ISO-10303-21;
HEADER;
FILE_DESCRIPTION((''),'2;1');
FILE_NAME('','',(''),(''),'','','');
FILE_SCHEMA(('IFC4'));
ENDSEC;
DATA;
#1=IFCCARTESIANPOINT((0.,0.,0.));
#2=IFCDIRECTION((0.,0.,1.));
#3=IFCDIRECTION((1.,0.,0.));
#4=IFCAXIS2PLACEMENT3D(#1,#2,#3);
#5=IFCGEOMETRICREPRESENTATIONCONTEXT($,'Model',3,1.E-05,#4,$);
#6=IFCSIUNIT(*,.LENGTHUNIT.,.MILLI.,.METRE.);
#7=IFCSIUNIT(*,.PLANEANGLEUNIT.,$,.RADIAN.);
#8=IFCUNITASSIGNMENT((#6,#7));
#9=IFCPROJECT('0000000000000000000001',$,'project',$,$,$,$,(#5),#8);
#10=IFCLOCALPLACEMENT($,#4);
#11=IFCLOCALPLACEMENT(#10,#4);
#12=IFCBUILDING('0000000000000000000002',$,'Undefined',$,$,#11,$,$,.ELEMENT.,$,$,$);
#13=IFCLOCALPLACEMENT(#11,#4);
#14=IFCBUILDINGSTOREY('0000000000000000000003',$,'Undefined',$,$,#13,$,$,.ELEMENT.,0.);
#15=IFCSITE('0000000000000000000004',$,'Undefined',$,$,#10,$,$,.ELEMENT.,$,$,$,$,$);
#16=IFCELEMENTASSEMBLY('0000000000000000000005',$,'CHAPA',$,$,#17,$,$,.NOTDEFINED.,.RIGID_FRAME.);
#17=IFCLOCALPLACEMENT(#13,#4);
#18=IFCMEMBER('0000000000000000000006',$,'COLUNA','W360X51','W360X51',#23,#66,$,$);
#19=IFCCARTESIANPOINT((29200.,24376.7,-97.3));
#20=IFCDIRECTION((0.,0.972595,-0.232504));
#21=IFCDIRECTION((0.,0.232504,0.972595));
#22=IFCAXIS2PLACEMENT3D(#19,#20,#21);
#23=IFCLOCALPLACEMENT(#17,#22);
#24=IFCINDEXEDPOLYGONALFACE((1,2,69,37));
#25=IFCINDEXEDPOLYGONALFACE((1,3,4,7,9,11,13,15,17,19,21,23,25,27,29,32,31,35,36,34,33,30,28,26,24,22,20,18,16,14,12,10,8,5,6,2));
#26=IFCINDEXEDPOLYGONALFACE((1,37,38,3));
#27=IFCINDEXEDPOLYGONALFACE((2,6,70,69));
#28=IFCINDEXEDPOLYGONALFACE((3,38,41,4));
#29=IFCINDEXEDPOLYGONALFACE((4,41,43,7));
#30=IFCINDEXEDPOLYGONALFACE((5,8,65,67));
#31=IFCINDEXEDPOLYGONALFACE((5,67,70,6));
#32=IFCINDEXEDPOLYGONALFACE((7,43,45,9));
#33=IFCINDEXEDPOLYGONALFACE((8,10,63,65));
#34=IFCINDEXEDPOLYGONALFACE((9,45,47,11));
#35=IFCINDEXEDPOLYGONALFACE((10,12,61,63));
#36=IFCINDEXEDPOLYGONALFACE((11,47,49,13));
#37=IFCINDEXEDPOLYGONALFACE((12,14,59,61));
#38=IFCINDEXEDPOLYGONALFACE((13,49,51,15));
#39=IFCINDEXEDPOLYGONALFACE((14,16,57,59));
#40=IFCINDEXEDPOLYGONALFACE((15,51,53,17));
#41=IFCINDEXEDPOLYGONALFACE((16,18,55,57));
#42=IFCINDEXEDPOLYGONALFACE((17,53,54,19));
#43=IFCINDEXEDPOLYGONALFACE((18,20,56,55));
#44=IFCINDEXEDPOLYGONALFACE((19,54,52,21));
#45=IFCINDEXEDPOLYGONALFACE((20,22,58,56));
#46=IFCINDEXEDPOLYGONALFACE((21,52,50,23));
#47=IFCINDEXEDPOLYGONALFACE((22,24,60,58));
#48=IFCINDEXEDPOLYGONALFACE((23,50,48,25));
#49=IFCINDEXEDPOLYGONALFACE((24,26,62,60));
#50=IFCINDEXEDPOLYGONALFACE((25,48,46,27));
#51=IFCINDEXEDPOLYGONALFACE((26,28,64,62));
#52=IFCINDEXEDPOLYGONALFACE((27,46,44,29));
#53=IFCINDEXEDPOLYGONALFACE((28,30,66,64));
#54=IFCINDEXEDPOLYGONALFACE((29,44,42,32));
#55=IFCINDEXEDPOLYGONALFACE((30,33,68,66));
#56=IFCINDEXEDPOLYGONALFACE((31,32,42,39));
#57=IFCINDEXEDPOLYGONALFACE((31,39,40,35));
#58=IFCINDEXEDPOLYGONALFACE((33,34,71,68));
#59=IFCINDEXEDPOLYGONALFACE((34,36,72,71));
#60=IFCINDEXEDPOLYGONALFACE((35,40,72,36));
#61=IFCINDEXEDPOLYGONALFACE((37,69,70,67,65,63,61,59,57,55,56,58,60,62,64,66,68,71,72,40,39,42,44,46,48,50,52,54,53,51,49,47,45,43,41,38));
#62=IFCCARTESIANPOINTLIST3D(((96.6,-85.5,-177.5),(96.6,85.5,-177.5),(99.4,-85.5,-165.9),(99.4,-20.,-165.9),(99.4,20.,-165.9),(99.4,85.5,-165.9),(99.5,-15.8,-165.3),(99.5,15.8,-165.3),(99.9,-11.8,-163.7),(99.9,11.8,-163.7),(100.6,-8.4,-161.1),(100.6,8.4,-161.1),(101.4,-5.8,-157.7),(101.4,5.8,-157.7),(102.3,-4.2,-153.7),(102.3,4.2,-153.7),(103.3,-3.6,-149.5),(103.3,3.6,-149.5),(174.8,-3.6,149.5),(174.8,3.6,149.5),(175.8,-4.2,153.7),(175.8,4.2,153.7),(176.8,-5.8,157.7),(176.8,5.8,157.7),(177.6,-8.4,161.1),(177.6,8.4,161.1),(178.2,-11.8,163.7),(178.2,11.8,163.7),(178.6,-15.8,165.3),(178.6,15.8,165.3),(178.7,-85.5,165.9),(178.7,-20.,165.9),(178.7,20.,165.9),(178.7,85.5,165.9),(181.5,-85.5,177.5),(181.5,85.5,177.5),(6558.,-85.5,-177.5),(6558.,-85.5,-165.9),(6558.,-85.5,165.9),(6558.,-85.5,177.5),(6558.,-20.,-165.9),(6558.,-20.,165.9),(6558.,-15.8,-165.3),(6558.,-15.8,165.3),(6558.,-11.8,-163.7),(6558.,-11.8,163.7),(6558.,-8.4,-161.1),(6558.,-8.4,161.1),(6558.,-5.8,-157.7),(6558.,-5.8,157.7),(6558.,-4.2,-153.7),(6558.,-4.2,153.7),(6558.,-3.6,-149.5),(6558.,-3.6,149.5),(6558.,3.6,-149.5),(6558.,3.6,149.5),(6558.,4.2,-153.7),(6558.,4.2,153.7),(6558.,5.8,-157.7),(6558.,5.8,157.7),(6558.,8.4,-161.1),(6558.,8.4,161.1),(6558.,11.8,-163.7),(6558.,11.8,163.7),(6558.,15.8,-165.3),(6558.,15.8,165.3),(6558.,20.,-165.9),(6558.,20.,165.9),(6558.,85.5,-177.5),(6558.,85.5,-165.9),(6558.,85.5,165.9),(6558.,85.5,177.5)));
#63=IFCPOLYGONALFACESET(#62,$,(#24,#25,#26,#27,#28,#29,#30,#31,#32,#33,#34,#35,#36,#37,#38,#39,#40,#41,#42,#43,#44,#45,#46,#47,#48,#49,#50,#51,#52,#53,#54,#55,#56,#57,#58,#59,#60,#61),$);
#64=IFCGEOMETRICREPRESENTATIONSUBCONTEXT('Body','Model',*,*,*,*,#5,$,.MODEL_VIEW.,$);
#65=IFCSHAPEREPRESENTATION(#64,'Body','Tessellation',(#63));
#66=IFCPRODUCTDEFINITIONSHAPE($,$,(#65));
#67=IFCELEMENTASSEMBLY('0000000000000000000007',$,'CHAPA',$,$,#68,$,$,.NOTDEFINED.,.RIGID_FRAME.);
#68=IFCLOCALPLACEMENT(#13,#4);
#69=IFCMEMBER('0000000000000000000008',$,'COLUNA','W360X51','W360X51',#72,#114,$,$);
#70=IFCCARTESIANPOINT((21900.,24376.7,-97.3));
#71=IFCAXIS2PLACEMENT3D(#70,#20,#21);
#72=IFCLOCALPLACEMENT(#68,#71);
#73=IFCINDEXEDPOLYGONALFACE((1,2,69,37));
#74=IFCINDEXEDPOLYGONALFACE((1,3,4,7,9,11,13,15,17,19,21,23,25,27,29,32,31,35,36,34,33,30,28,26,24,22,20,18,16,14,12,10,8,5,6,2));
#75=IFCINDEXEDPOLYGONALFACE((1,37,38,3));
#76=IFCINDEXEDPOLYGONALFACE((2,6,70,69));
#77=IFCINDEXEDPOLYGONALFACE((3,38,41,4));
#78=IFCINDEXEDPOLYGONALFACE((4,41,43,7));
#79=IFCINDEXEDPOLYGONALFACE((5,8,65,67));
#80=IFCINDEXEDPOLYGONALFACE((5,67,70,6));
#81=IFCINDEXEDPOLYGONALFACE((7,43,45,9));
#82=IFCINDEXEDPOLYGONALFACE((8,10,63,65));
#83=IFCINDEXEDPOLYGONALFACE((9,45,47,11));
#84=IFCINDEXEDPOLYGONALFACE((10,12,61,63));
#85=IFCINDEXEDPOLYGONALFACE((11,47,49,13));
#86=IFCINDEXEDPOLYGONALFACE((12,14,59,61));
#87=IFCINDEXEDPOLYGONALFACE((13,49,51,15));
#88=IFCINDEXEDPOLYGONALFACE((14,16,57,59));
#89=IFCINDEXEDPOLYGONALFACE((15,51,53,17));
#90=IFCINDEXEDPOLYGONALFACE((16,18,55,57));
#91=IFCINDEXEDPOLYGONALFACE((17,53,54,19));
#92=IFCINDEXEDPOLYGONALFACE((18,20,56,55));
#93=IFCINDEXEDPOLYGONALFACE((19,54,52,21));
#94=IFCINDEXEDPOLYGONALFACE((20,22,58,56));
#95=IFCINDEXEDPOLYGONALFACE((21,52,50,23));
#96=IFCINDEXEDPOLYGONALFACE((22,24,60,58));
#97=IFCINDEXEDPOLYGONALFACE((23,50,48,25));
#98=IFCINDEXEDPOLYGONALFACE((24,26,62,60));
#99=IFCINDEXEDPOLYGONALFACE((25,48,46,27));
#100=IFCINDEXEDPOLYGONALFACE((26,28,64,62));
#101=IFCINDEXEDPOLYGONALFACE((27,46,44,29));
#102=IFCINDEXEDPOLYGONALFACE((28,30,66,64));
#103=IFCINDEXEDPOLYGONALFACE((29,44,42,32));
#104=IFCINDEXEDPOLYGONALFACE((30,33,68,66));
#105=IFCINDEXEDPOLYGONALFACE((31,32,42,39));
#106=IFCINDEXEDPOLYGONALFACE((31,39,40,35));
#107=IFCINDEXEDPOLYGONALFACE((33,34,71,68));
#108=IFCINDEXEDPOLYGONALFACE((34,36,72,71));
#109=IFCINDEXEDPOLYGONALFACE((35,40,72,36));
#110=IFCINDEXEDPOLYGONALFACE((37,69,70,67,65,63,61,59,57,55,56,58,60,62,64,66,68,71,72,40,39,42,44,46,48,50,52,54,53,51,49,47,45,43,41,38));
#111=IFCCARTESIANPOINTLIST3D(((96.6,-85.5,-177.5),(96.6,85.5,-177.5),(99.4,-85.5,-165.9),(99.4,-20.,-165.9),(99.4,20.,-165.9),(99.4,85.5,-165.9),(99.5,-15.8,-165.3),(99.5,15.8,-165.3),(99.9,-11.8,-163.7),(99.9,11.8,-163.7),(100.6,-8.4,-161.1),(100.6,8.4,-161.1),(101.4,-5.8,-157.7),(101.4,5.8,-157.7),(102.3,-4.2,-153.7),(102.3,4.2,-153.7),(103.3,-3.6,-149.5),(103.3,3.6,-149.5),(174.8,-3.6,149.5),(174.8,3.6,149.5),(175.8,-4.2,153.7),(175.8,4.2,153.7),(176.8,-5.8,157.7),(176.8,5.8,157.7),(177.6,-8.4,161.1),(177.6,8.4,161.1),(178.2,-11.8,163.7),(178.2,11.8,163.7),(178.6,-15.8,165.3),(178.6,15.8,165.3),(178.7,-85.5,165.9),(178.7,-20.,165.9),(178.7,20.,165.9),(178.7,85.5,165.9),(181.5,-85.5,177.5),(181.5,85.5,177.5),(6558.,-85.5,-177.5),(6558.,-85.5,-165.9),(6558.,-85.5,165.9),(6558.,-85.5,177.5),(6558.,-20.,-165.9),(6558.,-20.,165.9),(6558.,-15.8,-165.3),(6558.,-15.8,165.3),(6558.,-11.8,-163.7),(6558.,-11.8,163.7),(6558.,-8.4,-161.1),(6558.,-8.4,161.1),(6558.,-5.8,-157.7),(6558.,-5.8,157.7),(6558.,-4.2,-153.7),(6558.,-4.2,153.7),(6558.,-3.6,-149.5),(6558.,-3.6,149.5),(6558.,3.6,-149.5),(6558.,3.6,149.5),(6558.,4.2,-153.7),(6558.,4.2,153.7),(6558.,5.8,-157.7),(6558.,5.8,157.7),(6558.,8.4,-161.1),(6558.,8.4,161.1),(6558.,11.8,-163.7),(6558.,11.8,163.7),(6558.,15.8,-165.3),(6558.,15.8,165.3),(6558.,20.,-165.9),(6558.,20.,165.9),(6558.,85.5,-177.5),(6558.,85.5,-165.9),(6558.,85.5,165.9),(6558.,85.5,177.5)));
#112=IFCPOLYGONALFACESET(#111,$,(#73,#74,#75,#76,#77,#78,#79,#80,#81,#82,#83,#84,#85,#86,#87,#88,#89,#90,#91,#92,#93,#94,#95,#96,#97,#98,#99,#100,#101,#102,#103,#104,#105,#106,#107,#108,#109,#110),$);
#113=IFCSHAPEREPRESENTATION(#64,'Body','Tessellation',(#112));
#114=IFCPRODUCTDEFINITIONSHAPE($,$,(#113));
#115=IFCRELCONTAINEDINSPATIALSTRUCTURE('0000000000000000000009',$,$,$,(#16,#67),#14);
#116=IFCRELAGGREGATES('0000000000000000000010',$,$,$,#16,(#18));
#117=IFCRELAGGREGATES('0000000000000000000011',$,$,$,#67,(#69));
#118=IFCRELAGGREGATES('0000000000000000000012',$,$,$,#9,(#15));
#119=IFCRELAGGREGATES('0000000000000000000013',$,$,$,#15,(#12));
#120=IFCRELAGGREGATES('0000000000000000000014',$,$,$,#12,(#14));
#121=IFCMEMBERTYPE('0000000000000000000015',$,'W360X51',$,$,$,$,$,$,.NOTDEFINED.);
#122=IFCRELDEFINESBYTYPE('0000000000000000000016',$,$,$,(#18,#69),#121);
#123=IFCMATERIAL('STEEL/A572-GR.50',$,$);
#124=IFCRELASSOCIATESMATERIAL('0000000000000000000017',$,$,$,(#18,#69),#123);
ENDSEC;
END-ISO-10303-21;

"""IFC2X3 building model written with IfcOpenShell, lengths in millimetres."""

from ifc_helpers import new_model, si_unit, frame, origin_with_axes, origin_2d_with_axis, place, context, subcontext, project, spatial, i_section, extrude, clip, halfspace, material, type_object, element, aggregate, save


model = new_model("IFC2X3")

# Units and contexts
model_context = context("Model", 3, precision=1e-05, world=origin_with_axes())
body_context = subcontext(model_context, "Body", "Model", "MODEL_VIEW")
ifc_project = project(units=[si_unit("LENGTHUNIT", "METRE", prefix="MILLI"), si_unit("PLANEANGLEUNIT", "RADIAN")], contexts=[model_context])

# Site, building, storey
site_placement = place(None, origin_with_axes())
site = spatial("IfcSite", under=ifc_project, at=site_placement, Name="Undefined", CompositionType="ELEMENT")
building_placement = place(site_placement, origin_with_axes())
building = spatial("IfcBuilding", under=site, at=building_placement, Name="Undefined", CompositionType="ELEMENT")
storey_placement = place(building_placement, origin_with_axes())
storey = spatial("IfcBuildingStorey", under=building, at=storey_placement, Name="Undefined", CompositionType="ELEMENT", Elevation=0.0)

# Element assemblies, members
assembly_1_placement = place(storey_placement, origin_with_axes())
assembly_1 = element("IfcElementAssembly", 1, at=assembly_1_placement, inside=storey, Name="CHAPA", AssemblyPlace="NOTDEFINED", PredefinedType="RIGID_FRAME")
ifc_material_1 = material(Name="STEEL/A572-GR.50")
member_type = type_object("IfcMemberType", Name="W360X51", PredefinedType="NOTDEFINED")
member_1_placement = place(assembly_1_placement, frame((29200.0, 24376.7, -97.3), z_axis=(0.0, 0.972595, -0.232504), x_axis=(0.0, 0.232504, 0.972595)))
member_1 = element("IfcMember", 2, at=member_1_placement, type_object=member_type, material=ifc_material_1, Name="COLUNA", Description="W360X51", ObjectType="W360X51", context=body_context, shape_type="Clipping", body=[
    clip(clip(extrude(i_section(OverallWidth=171.0, OverallDepth=355.0, WebThickness=7.2, FlangeThickness=11.6, FilletRadius=16.4, at=origin_2d_with_axis()), frame((6558.0, 0.0, 0.0), z_axis=(-1.0, 0.0, 0.0), x_axis=(0.0, -1.0, 0.0)), (0.0, 0.0, 1.0), 6542.9), halfspace(frame((94.5, -85.5, -186.3), z_axis=(-0.972595, 0.0, 0.232504), x_axis=(0.0, 1.0, 0.0)), False)), halfspace(frame((96.6, 0.0, -177.5), z_axis=(0.972595, 0.0, -0.232504), x_axis=(0.0, -1.0, 0.0)), True)),
])
assembly_2_placement = place(storey_placement, origin_with_axes())
assembly_2 = element("IfcElementAssembly", 3, at=assembly_2_placement, inside=storey, Name="CHAPA", AssemblyPlace="NOTDEFINED", PredefinedType="RIGID_FRAME")
member_2_placement = place(assembly_2_placement, frame((21900.0, 24376.7, -97.3), z_axis=(0.0, 0.972595, -0.232504), x_axis=(0.0, 0.232504, 0.972595)))
member_2 = element("IfcMember", 4, at=member_2_placement, type_object=member_type, material=ifc_material_1, Name="COLUNA", Description="W360X51", ObjectType="W360X51", context=body_context, shape_type="Clipping", body=[
    clip(clip(extrude(i_section(OverallWidth=171.0, OverallDepth=355.0, WebThickness=7.2, FlangeThickness=11.6, FilletRadius=16.4, at=origin_2d_with_axis()), frame((6558.0, 0.0, 0.0), z_axis=(-1.0, 0.0, 0.0), x_axis=(0.0, -1.0, 0.0)), (0.0, 0.0, 1.0), 6542.9), halfspace(frame((94.5, -85.5, -186.3), z_axis=(-0.972595, 0.0, 0.232504), x_axis=(0.0, 1.0, 0.0)), False)), halfspace(frame((96.6, 0.0, -177.5), z_axis=(0.972595, 0.0, -0.232504), x_axis=(0.0, -1.0, 0.0)), True)),
])

aggregate(assembly_1, [member_1])
aggregate(assembly_2, [member_2])

save(model, "model.ifc")
